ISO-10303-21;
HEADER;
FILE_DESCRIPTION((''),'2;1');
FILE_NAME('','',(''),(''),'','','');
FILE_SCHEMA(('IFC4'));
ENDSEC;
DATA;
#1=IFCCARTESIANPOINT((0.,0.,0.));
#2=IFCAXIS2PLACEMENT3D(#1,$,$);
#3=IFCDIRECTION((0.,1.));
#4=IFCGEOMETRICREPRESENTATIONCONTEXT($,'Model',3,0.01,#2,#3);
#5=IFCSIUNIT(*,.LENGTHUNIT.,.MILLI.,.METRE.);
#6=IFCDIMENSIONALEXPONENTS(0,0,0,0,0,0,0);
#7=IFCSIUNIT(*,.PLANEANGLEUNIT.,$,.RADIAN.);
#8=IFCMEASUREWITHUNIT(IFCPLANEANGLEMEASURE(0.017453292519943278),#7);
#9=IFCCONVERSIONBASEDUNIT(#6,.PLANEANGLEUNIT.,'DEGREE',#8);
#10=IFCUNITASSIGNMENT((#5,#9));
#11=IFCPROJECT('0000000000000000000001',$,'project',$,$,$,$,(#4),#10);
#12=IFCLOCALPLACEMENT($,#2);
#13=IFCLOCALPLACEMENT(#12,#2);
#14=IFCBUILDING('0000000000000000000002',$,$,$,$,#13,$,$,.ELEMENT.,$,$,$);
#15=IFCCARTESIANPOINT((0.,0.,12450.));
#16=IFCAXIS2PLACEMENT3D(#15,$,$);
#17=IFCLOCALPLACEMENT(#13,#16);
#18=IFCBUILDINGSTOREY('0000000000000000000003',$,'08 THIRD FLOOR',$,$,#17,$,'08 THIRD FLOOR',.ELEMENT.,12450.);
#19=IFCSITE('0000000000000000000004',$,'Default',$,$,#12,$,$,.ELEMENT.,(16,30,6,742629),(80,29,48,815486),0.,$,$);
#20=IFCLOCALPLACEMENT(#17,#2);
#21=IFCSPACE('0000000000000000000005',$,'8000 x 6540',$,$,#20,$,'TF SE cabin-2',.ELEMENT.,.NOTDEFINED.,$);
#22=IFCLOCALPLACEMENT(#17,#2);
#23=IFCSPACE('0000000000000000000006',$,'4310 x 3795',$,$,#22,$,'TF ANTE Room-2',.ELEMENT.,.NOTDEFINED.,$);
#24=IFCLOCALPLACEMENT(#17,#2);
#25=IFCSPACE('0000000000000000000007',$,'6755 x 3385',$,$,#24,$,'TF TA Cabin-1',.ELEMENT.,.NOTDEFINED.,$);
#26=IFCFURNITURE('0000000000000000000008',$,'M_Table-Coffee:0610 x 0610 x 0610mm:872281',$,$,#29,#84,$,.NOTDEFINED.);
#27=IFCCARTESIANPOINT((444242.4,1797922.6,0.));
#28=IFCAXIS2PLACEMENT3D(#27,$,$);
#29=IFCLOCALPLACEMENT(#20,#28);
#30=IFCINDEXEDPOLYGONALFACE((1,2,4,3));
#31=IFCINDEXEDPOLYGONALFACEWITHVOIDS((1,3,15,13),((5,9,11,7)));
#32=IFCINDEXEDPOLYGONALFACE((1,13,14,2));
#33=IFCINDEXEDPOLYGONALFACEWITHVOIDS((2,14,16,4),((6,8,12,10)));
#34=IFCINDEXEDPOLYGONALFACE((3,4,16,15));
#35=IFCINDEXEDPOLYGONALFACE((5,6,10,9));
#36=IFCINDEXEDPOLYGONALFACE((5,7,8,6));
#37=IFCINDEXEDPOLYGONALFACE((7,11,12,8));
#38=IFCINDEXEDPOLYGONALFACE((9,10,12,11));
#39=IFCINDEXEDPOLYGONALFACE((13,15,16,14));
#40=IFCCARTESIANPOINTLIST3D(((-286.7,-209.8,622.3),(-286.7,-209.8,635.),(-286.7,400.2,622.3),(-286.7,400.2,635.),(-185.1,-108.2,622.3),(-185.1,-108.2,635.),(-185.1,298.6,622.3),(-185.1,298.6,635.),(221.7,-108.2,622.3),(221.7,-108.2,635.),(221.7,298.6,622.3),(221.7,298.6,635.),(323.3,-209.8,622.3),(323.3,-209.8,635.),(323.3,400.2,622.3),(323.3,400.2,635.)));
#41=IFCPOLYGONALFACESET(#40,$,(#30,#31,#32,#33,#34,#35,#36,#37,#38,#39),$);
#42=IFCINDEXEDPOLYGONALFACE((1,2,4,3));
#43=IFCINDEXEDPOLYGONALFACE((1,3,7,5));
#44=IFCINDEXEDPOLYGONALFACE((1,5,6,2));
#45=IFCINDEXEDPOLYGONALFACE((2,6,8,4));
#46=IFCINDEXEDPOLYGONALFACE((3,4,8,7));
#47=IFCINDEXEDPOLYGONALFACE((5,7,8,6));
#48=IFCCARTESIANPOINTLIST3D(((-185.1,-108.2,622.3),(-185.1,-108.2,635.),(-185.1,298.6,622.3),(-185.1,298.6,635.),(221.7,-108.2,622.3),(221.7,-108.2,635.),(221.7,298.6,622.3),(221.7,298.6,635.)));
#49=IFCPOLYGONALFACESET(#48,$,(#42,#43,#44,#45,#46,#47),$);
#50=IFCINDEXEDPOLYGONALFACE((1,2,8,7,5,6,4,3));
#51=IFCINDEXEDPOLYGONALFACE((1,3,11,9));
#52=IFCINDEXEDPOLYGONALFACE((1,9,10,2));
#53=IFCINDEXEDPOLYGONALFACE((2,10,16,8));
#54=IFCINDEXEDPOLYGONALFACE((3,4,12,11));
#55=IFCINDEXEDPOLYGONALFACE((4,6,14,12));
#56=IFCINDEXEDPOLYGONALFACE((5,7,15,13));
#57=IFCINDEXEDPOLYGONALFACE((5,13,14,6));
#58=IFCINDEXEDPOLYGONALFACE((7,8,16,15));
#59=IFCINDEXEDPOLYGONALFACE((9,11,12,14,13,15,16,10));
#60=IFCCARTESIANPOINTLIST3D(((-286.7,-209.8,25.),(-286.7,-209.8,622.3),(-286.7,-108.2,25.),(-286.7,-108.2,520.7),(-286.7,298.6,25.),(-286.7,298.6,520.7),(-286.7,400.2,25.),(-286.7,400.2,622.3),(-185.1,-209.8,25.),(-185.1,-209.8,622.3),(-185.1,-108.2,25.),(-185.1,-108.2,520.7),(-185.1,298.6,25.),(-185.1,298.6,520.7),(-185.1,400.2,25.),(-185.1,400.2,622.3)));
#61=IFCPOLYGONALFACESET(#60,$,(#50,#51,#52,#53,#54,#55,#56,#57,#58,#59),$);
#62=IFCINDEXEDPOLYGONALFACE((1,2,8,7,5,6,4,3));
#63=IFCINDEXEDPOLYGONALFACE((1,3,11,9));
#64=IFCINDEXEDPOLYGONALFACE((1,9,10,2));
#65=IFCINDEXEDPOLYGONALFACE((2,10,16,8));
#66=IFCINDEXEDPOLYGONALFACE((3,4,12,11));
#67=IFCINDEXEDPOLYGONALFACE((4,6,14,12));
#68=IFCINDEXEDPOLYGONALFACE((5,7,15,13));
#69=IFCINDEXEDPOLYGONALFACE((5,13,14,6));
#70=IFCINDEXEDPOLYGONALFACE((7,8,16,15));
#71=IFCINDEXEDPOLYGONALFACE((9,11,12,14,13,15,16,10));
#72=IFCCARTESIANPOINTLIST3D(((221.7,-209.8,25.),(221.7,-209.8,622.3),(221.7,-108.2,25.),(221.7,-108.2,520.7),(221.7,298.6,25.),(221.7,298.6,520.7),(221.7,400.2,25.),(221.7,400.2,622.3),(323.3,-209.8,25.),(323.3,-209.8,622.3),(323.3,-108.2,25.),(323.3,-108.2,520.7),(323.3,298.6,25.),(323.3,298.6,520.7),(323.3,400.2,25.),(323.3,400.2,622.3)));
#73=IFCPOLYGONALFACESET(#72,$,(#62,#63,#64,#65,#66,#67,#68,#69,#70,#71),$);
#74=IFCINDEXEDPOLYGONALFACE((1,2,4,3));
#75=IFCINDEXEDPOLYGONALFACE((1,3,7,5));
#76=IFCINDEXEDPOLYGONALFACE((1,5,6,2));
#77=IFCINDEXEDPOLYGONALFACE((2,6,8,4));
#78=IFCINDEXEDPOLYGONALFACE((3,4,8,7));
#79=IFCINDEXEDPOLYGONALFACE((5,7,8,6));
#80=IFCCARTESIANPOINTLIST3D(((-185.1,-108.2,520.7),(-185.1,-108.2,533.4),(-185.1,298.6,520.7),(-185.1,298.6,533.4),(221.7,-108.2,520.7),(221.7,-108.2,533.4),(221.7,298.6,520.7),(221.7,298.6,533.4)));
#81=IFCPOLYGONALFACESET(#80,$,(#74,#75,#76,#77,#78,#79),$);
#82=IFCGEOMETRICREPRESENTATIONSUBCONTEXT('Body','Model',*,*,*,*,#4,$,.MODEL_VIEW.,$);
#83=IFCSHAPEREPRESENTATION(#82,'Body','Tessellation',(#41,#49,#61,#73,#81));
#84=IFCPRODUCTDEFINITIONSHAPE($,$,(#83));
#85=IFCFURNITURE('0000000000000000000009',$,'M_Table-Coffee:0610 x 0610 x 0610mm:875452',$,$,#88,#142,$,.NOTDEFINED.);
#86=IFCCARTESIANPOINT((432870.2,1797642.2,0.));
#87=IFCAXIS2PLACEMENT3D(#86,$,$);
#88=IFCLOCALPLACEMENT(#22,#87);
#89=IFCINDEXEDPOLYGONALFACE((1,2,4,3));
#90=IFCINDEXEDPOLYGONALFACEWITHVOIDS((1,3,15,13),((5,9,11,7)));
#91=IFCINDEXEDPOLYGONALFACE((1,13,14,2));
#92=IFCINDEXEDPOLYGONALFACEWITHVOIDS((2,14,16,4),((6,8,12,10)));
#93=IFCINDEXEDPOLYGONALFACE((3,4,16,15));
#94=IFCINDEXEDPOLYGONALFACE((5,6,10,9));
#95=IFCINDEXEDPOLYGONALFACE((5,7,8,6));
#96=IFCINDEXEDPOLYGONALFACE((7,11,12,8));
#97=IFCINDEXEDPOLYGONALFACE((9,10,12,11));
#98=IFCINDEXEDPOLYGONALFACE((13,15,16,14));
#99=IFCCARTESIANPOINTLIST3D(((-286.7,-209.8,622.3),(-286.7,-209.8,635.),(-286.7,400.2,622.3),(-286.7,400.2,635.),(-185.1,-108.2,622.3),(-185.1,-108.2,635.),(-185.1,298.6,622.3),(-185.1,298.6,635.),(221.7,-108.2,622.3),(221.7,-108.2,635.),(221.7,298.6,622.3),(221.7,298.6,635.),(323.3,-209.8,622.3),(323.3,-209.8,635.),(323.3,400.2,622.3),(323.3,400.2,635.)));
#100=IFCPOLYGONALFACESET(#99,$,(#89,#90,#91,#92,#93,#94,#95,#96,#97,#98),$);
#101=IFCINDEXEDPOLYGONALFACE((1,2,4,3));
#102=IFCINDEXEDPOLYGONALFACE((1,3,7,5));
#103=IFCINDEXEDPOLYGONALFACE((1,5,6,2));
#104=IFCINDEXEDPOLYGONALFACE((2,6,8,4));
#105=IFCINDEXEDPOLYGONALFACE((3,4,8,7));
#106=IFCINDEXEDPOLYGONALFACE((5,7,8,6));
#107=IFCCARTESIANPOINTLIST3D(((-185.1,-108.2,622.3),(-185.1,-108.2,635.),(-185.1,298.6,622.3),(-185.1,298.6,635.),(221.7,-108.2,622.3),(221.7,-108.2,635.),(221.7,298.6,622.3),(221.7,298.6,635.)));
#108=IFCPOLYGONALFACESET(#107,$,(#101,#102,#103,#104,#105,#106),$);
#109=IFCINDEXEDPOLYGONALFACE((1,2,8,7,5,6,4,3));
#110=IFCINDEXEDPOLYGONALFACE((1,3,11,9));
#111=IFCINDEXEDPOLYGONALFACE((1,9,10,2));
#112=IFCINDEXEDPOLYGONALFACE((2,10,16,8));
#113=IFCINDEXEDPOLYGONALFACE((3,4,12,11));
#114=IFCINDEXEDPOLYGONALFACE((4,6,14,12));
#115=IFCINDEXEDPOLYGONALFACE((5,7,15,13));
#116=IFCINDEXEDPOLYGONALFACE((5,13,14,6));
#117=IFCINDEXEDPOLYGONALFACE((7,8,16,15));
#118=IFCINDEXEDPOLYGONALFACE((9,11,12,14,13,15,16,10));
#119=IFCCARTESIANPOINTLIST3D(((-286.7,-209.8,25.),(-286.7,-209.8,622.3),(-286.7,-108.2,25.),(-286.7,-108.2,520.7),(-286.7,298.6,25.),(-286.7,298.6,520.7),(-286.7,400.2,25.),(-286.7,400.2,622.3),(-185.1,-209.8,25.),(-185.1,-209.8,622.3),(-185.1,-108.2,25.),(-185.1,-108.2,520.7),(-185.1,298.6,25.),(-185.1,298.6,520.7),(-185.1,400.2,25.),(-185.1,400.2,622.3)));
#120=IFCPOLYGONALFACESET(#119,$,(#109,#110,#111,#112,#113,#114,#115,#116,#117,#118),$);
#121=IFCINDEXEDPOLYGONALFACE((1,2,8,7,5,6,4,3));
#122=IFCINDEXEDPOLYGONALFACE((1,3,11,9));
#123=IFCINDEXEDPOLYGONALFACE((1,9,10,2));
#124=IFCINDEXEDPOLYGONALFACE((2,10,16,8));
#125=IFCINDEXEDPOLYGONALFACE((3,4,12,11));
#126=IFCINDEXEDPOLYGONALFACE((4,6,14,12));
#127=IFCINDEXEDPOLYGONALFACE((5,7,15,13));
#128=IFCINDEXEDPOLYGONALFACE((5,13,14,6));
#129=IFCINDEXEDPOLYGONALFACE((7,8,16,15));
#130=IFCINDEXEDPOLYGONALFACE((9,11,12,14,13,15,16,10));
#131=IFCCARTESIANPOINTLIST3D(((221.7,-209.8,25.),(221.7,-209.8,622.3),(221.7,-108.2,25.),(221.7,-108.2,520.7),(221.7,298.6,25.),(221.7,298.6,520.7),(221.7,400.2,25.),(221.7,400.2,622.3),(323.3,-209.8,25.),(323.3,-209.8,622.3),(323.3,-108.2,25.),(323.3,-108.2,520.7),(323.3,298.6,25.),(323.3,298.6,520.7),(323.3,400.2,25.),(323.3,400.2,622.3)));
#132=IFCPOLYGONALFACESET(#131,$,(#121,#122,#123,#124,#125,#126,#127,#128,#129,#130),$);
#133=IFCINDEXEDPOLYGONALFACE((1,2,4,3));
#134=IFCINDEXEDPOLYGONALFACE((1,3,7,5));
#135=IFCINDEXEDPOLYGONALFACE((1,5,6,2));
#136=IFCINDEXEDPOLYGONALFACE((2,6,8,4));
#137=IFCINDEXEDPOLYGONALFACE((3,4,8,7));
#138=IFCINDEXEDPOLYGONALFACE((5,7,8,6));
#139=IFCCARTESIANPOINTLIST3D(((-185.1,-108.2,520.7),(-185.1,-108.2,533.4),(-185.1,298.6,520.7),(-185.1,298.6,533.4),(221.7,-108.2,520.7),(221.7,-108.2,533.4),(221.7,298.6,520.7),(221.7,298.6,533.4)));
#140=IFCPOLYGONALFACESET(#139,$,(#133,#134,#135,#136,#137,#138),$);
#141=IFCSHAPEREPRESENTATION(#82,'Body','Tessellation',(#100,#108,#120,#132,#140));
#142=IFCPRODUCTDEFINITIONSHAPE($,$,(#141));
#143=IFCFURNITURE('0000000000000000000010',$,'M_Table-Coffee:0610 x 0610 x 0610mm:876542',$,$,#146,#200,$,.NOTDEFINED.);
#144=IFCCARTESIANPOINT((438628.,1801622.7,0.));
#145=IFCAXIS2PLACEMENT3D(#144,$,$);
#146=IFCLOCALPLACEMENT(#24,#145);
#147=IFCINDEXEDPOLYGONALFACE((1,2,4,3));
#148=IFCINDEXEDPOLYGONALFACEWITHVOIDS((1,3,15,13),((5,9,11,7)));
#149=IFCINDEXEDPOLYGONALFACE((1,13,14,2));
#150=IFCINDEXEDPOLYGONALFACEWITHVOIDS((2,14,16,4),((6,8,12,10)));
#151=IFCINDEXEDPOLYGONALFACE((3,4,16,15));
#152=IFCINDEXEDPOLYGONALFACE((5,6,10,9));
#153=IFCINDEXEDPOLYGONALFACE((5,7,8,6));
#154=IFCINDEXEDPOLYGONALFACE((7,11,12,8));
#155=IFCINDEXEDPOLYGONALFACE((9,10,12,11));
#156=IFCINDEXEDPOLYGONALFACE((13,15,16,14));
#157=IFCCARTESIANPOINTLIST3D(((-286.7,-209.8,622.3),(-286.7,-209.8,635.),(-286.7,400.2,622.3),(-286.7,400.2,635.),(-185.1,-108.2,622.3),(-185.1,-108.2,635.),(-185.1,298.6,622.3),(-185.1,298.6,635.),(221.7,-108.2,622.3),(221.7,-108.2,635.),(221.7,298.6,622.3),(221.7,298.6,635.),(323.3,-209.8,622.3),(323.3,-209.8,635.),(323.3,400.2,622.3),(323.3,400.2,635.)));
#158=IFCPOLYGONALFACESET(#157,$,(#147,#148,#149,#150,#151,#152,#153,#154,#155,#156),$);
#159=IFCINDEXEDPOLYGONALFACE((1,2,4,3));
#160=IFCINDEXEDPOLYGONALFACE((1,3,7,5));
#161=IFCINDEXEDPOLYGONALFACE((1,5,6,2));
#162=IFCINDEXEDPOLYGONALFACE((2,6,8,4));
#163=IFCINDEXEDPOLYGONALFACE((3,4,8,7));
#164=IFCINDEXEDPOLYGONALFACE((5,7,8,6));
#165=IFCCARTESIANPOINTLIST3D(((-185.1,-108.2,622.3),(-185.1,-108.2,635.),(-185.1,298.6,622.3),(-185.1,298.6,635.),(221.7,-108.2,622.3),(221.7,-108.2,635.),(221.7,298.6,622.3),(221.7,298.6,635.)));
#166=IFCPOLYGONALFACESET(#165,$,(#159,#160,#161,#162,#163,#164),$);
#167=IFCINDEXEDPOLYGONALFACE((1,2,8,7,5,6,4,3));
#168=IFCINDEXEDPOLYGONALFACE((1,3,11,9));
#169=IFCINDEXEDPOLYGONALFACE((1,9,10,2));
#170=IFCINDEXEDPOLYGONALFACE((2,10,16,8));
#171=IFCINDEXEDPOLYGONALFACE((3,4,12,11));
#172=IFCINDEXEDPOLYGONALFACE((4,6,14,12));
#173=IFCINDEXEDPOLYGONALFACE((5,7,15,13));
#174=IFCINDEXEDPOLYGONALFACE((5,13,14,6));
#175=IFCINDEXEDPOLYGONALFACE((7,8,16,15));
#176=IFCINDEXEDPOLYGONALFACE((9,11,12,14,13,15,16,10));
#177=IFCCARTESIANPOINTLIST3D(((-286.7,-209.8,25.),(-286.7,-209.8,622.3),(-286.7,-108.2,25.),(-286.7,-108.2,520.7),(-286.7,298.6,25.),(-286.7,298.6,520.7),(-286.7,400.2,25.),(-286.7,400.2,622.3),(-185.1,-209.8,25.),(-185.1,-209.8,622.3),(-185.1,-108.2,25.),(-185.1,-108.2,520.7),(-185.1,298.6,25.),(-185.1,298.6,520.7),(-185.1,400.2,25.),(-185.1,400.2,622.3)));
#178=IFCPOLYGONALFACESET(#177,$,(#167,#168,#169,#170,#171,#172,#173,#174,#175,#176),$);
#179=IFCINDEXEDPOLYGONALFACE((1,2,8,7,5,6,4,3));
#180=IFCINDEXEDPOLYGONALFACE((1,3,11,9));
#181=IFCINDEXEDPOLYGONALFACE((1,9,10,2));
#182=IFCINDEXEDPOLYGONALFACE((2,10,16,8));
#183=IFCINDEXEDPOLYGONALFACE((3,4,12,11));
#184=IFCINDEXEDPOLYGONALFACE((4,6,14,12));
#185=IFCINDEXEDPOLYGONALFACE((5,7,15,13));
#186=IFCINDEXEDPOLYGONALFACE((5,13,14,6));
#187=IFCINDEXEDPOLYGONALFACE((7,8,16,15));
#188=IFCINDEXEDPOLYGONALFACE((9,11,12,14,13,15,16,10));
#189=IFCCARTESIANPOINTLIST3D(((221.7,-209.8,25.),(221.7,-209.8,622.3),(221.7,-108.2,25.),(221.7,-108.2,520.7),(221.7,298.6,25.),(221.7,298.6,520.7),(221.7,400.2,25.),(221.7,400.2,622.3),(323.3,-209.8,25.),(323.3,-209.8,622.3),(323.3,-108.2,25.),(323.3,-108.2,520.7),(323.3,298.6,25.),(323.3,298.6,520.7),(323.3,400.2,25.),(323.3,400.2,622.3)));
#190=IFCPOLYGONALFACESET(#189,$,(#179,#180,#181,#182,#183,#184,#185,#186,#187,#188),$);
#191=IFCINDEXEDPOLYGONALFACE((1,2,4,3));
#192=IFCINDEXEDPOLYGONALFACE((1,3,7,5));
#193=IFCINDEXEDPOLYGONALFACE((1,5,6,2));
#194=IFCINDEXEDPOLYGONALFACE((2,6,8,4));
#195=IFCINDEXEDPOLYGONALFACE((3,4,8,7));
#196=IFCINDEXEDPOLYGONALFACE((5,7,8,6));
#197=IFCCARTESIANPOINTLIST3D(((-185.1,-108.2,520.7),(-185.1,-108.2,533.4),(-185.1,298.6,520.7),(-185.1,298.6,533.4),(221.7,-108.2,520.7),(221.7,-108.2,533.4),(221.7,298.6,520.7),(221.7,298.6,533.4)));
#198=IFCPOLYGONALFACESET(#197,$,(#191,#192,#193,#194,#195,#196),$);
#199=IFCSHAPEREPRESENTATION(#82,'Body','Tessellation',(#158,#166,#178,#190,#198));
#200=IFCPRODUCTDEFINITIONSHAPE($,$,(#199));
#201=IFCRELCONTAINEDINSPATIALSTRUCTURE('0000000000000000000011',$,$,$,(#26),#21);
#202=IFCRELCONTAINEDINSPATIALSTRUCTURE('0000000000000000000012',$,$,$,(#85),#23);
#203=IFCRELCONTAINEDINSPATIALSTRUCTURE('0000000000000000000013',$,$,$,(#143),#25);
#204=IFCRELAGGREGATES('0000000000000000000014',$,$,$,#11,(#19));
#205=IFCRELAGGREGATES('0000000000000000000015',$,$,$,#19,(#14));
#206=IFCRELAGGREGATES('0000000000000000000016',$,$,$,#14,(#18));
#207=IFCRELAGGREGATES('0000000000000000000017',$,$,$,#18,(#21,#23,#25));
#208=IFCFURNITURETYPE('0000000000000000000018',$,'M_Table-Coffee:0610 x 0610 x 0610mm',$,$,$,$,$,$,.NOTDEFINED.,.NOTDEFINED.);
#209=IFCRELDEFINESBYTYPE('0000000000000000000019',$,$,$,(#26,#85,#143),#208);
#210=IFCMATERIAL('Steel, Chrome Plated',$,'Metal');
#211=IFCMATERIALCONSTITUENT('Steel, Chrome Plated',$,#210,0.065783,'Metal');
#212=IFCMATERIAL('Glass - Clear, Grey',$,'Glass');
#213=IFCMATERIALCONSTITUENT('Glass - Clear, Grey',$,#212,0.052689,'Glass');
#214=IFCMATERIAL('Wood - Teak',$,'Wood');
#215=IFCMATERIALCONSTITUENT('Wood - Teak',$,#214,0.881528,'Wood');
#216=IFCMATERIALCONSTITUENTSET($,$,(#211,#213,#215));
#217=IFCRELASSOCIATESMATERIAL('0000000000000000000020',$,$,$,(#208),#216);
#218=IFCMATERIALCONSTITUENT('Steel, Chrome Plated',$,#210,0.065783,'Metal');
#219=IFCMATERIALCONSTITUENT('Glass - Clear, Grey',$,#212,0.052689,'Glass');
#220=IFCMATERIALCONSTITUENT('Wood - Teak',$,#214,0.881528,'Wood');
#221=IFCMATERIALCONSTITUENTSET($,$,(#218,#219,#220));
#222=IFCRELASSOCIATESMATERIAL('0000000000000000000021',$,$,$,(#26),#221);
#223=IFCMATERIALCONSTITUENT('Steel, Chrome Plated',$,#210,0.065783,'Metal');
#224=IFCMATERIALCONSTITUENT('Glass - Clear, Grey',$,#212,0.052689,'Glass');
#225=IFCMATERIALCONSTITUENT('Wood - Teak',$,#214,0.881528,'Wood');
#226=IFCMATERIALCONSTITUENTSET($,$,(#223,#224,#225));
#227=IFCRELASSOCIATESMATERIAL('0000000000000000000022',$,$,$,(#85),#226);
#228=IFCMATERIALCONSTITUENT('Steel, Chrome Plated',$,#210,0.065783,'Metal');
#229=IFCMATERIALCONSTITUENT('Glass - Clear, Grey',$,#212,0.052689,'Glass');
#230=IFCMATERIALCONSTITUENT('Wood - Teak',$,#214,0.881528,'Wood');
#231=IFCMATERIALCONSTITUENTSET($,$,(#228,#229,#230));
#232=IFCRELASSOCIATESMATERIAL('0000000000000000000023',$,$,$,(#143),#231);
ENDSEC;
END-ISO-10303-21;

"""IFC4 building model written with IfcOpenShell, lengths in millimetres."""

from ifc_helpers import new_model, entity, si_unit, converted_unit, direction, frame, origin, place, context, subcontext, project, spatial, indexed_curve, outline, extrude, source, transform, mapped, material, constituent, constituent_set, type_object, type_shapes, element, save


model = new_model("IFC4")

# Units and contexts
model_context = context("Model", 3, precision=0.01, world=origin(), true_north=direction((0.0, 1.0)))
body_context = subcontext(model_context, "Body", "Model", "MODEL_VIEW")
ifc_project = project(units=[si_unit("LENGTHUNIT", "METRE", prefix="MILLI"), converted_unit("PLANEANGLEUNIT", "DEGREE", entity("IfcPlaneAngleMeasure", 0.017453292519943278), si_unit("PLANEANGLEUNIT", "RADIAN"), dimensions=[0, 0, 0, 0, 0, 0, 0])], contexts=[model_context])

# Site, building, storey
site_placement = place(None, origin())
site = spatial("IfcSite", under=ifc_project, at=site_placement, Name="Default", CompositionType="ELEMENT", RefLatitude=(16, 30, 6, 742629), RefLongitude=(80, 29, 48, 815486), RefElevation=0.0)
building_placement = place(site_placement, origin())
building = spatial("IfcBuilding", under=site, at=building_placement, CompositionType="ELEMENT")
storey_placement = place(building_placement, frame((0.0, 0.0, 12450.0)))
storey = spatial("IfcBuildingStorey", under=building, at=storey_placement, Name="08 THIRD FLOOR", LongName="08 THIRD FLOOR", CompositionType="ELEMENT", Elevation=12450.0)

# Shared definitions
space_1_placement = place(storey_placement, origin())
space_1 = spatial("IfcSpace", under=storey, at=space_1_placement, Name="8000 x 6540", LongName="TF SE cabin-2", CompositionType="ELEMENT", PredefinedType="NOTDEFINED")

# Furniture
ifc_material_1 = material(Name="Steel, Chrome Plated", Category="Metal")
ifc_constituent_1 = constituent(ifc_material_1, Name="Steel, Chrome Plated", Category="Metal", fraction=0.065783)
ifc_material_2 = material(Name="Glass - Clear, Grey", Category="Glass")
ifc_constituent_2 = constituent(ifc_material_2, Name="Glass - Clear, Grey", Category="Glass", fraction=0.052689)
ifc_material_3 = material(Name="Wood - Teak", Category="Wood")
ifc_constituent_3 = constituent(ifc_material_3, Name="Wood - Teak", Category="Wood", fraction=0.881528)
ifc_constituent_set_1 = constituent_set(constituents=[ifc_constituent_1, ifc_constituent_2, ifc_constituent_3])
ifc_constituent_4 = constituent(ifc_material_1, Name="Steel, Chrome Plated", Category="Metal", fraction=0.065783)
ifc_constituent_5 = constituent(ifc_material_2, Name="Glass - Clear, Grey", Category="Glass", fraction=0.052689)
ifc_constituent_6 = constituent(ifc_material_3, Name="Wood - Teak", Category="Wood", fraction=0.881528)
ifc_constituent_set_2 = constituent_set(constituents=[ifc_constituent_4, ifc_constituent_5, ifc_constituent_6])
furniture_type_1 = type_object("IfcFurnitureType", Name="M_Table-Coffee:0610 x 0610 x 0610mm", AssemblyPlace="NOTDEFINED", PredefinedType="NOTDEFINED", material=ifc_constituent_set_2)
shared_shape_1 = source(origin(), body_context, "Body", "SweptSolid", [
    extrude(outline(indexed_curve([(-305.0, -305.0), (305.0, -305.0), (305.0, 305.0), (-305.0, 305.0), (-305.0, -305.0)], self_intersect=False), holes=[indexed_curve([(-203.4, -203.4), (-203.4, 203.4), (203.4, 203.4), (203.4, -203.4), (-203.4, -203.4)], self_intersect=False)]), frame((18.3, 95.2, 622.3), z_axis=(0.0, 0.0, 1.0), x_axis=(-1.0, 0.0, 0.0)), (0.0, 0.0, 1.0), 12.7),
    extrude(outline(indexed_curve([(-203.4, -203.4), (203.4, -203.4), (203.4, 203.4), (-203.4, 203.4), (-203.4, -203.4)], self_intersect=False)), frame((18.3, 95.2, 622.3), z_axis=(0.0, 0.0, 1.0), x_axis=(-1.0, 0.0, 0.0)), (0.0, 0.0, 1.0), 12.7),
    extrude(outline(indexed_curve([(-305.0, -324.1), (305.0, -324.1), (305.0, 273.3), (203.4, 273.3), (203.4, -222.4), (-203.4, -222.4), (-203.4, 273.3), (-305.0, 273.3), (-305.0, -324.1)], self_intersect=False)), frame((-286.7, 95.2, 298.3), z_axis=(1.0, 0.0, 0.0), x_axis=(0.0, -1.0, 0.0)), (0.0, 0.0, 1.0), 101.6),
    extrude(outline(indexed_curve([(-273.2, -305.0), (324.0, -305.0), (324.0, 305.0), (-273.2, 305.0), (-273.2, 203.4), (222.5, 203.4), (222.5, -203.4), (-273.2, -203.4), (-273.2, -305.0)], self_intersect=False)), frame((221.7, 95.2, 298.2), z_axis=(1.0, 0.0, 0.0), x_axis=(0.0, 0.0, 1.0)), (0.0, 0.0, 1.0), 101.6),
    extrude(outline(indexed_curve([(-203.4, -203.4), (203.4, -203.4), (203.4, 203.4), (-203.4, 203.4), (-203.4, -203.4)], self_intersect=False)), frame((18.3, 95.2, 520.7), z_axis=(0.0, 0.0, 1.0), x_axis=(-1.0, 0.0, 0.0)), (0.0, 0.0, 1.0), 12.7),
])
type_shapes(furniture_type_1, [shared_shape_1])
furniture_1_placement = place(space_1_placement, frame((444242.4, 1797922.6, 0.0)))
element("IfcFurniture", 1, at=furniture_1_placement, inside=space_1, type_object=furniture_type_1, material=ifc_constituent_set_1, Name="M_Table-Coffee:0610 x 0610 x 0610mm:872281", PredefinedType="NOTDEFINED", context=body_context, shape_type="MappedRepresentation", body=[
    mapped(shared_shape_1, transform((0.0, 0.0, 0.0), scale=1.0)),
])

# Shared definitions
space_2_placement = place(storey_placement, origin())
space_2 = spatial("IfcSpace", under=storey, at=space_2_placement, Name="4310 x 3795", LongName="TF ANTE Room-2", CompositionType="ELEMENT", PredefinedType="NOTDEFINED")

# Furniture
ifc_constituent_7 = constituent(ifc_material_1, Name="Steel, Chrome Plated", Category="Metal", fraction=0.065783)
ifc_constituent_8 = constituent(ifc_material_2, Name="Glass - Clear, Grey", Category="Glass", fraction=0.052689)
ifc_constituent_9 = constituent(ifc_material_3, Name="Wood - Teak", Category="Wood", fraction=0.881528)
ifc_constituent_set_3 = constituent_set(constituents=[ifc_constituent_7, ifc_constituent_8, ifc_constituent_9])
furniture_2_placement = place(space_2_placement, frame((432870.2, 1797642.2, 0.0)))
element("IfcFurniture", 2, at=furniture_2_placement, inside=space_2, type_object=furniture_type_1, material=ifc_constituent_set_3, Name="M_Table-Coffee:0610 x 0610 x 0610mm:875452", PredefinedType="NOTDEFINED", context=body_context, shape_type="MappedRepresentation", body=[
    mapped(shared_shape_1, transform((0.0, 0.0, 0.0), scale=1.0)),
])

# Shared definitions
space_3_placement = place(storey_placement, origin())
space_3 = spatial("IfcSpace", under=storey, at=space_3_placement, Name="6755 x 3385", LongName="TF TA Cabin-1", CompositionType="ELEMENT", PredefinedType="NOTDEFINED")

# Furniture
ifc_constituent_10 = constituent(ifc_material_1, Name="Steel, Chrome Plated", Category="Metal", fraction=0.065783)
ifc_constituent_11 = constituent(ifc_material_2, Name="Glass - Clear, Grey", Category="Glass", fraction=0.052689)
ifc_constituent_12 = constituent(ifc_material_3, Name="Wood - Teak", Category="Wood", fraction=0.881528)
ifc_constituent_set_4 = constituent_set(constituents=[ifc_constituent_10, ifc_constituent_11, ifc_constituent_12])
furniture_3_placement = place(space_3_placement, frame((438628.0, 1801622.7, 0.0)))
element("IfcFurniture", 3, at=furniture_3_placement, inside=space_3, type_object=furniture_type_1, material=ifc_constituent_set_4, Name="M_Table-Coffee:0610 x 0610 x 0610mm:876542", PredefinedType="NOTDEFINED", context=body_context, shape_type="MappedRepresentation", body=[
    mapped(shared_shape_1, transform((0.0, 0.0, 0.0), scale=1.0)),
])

save(model, "model.ifc")
